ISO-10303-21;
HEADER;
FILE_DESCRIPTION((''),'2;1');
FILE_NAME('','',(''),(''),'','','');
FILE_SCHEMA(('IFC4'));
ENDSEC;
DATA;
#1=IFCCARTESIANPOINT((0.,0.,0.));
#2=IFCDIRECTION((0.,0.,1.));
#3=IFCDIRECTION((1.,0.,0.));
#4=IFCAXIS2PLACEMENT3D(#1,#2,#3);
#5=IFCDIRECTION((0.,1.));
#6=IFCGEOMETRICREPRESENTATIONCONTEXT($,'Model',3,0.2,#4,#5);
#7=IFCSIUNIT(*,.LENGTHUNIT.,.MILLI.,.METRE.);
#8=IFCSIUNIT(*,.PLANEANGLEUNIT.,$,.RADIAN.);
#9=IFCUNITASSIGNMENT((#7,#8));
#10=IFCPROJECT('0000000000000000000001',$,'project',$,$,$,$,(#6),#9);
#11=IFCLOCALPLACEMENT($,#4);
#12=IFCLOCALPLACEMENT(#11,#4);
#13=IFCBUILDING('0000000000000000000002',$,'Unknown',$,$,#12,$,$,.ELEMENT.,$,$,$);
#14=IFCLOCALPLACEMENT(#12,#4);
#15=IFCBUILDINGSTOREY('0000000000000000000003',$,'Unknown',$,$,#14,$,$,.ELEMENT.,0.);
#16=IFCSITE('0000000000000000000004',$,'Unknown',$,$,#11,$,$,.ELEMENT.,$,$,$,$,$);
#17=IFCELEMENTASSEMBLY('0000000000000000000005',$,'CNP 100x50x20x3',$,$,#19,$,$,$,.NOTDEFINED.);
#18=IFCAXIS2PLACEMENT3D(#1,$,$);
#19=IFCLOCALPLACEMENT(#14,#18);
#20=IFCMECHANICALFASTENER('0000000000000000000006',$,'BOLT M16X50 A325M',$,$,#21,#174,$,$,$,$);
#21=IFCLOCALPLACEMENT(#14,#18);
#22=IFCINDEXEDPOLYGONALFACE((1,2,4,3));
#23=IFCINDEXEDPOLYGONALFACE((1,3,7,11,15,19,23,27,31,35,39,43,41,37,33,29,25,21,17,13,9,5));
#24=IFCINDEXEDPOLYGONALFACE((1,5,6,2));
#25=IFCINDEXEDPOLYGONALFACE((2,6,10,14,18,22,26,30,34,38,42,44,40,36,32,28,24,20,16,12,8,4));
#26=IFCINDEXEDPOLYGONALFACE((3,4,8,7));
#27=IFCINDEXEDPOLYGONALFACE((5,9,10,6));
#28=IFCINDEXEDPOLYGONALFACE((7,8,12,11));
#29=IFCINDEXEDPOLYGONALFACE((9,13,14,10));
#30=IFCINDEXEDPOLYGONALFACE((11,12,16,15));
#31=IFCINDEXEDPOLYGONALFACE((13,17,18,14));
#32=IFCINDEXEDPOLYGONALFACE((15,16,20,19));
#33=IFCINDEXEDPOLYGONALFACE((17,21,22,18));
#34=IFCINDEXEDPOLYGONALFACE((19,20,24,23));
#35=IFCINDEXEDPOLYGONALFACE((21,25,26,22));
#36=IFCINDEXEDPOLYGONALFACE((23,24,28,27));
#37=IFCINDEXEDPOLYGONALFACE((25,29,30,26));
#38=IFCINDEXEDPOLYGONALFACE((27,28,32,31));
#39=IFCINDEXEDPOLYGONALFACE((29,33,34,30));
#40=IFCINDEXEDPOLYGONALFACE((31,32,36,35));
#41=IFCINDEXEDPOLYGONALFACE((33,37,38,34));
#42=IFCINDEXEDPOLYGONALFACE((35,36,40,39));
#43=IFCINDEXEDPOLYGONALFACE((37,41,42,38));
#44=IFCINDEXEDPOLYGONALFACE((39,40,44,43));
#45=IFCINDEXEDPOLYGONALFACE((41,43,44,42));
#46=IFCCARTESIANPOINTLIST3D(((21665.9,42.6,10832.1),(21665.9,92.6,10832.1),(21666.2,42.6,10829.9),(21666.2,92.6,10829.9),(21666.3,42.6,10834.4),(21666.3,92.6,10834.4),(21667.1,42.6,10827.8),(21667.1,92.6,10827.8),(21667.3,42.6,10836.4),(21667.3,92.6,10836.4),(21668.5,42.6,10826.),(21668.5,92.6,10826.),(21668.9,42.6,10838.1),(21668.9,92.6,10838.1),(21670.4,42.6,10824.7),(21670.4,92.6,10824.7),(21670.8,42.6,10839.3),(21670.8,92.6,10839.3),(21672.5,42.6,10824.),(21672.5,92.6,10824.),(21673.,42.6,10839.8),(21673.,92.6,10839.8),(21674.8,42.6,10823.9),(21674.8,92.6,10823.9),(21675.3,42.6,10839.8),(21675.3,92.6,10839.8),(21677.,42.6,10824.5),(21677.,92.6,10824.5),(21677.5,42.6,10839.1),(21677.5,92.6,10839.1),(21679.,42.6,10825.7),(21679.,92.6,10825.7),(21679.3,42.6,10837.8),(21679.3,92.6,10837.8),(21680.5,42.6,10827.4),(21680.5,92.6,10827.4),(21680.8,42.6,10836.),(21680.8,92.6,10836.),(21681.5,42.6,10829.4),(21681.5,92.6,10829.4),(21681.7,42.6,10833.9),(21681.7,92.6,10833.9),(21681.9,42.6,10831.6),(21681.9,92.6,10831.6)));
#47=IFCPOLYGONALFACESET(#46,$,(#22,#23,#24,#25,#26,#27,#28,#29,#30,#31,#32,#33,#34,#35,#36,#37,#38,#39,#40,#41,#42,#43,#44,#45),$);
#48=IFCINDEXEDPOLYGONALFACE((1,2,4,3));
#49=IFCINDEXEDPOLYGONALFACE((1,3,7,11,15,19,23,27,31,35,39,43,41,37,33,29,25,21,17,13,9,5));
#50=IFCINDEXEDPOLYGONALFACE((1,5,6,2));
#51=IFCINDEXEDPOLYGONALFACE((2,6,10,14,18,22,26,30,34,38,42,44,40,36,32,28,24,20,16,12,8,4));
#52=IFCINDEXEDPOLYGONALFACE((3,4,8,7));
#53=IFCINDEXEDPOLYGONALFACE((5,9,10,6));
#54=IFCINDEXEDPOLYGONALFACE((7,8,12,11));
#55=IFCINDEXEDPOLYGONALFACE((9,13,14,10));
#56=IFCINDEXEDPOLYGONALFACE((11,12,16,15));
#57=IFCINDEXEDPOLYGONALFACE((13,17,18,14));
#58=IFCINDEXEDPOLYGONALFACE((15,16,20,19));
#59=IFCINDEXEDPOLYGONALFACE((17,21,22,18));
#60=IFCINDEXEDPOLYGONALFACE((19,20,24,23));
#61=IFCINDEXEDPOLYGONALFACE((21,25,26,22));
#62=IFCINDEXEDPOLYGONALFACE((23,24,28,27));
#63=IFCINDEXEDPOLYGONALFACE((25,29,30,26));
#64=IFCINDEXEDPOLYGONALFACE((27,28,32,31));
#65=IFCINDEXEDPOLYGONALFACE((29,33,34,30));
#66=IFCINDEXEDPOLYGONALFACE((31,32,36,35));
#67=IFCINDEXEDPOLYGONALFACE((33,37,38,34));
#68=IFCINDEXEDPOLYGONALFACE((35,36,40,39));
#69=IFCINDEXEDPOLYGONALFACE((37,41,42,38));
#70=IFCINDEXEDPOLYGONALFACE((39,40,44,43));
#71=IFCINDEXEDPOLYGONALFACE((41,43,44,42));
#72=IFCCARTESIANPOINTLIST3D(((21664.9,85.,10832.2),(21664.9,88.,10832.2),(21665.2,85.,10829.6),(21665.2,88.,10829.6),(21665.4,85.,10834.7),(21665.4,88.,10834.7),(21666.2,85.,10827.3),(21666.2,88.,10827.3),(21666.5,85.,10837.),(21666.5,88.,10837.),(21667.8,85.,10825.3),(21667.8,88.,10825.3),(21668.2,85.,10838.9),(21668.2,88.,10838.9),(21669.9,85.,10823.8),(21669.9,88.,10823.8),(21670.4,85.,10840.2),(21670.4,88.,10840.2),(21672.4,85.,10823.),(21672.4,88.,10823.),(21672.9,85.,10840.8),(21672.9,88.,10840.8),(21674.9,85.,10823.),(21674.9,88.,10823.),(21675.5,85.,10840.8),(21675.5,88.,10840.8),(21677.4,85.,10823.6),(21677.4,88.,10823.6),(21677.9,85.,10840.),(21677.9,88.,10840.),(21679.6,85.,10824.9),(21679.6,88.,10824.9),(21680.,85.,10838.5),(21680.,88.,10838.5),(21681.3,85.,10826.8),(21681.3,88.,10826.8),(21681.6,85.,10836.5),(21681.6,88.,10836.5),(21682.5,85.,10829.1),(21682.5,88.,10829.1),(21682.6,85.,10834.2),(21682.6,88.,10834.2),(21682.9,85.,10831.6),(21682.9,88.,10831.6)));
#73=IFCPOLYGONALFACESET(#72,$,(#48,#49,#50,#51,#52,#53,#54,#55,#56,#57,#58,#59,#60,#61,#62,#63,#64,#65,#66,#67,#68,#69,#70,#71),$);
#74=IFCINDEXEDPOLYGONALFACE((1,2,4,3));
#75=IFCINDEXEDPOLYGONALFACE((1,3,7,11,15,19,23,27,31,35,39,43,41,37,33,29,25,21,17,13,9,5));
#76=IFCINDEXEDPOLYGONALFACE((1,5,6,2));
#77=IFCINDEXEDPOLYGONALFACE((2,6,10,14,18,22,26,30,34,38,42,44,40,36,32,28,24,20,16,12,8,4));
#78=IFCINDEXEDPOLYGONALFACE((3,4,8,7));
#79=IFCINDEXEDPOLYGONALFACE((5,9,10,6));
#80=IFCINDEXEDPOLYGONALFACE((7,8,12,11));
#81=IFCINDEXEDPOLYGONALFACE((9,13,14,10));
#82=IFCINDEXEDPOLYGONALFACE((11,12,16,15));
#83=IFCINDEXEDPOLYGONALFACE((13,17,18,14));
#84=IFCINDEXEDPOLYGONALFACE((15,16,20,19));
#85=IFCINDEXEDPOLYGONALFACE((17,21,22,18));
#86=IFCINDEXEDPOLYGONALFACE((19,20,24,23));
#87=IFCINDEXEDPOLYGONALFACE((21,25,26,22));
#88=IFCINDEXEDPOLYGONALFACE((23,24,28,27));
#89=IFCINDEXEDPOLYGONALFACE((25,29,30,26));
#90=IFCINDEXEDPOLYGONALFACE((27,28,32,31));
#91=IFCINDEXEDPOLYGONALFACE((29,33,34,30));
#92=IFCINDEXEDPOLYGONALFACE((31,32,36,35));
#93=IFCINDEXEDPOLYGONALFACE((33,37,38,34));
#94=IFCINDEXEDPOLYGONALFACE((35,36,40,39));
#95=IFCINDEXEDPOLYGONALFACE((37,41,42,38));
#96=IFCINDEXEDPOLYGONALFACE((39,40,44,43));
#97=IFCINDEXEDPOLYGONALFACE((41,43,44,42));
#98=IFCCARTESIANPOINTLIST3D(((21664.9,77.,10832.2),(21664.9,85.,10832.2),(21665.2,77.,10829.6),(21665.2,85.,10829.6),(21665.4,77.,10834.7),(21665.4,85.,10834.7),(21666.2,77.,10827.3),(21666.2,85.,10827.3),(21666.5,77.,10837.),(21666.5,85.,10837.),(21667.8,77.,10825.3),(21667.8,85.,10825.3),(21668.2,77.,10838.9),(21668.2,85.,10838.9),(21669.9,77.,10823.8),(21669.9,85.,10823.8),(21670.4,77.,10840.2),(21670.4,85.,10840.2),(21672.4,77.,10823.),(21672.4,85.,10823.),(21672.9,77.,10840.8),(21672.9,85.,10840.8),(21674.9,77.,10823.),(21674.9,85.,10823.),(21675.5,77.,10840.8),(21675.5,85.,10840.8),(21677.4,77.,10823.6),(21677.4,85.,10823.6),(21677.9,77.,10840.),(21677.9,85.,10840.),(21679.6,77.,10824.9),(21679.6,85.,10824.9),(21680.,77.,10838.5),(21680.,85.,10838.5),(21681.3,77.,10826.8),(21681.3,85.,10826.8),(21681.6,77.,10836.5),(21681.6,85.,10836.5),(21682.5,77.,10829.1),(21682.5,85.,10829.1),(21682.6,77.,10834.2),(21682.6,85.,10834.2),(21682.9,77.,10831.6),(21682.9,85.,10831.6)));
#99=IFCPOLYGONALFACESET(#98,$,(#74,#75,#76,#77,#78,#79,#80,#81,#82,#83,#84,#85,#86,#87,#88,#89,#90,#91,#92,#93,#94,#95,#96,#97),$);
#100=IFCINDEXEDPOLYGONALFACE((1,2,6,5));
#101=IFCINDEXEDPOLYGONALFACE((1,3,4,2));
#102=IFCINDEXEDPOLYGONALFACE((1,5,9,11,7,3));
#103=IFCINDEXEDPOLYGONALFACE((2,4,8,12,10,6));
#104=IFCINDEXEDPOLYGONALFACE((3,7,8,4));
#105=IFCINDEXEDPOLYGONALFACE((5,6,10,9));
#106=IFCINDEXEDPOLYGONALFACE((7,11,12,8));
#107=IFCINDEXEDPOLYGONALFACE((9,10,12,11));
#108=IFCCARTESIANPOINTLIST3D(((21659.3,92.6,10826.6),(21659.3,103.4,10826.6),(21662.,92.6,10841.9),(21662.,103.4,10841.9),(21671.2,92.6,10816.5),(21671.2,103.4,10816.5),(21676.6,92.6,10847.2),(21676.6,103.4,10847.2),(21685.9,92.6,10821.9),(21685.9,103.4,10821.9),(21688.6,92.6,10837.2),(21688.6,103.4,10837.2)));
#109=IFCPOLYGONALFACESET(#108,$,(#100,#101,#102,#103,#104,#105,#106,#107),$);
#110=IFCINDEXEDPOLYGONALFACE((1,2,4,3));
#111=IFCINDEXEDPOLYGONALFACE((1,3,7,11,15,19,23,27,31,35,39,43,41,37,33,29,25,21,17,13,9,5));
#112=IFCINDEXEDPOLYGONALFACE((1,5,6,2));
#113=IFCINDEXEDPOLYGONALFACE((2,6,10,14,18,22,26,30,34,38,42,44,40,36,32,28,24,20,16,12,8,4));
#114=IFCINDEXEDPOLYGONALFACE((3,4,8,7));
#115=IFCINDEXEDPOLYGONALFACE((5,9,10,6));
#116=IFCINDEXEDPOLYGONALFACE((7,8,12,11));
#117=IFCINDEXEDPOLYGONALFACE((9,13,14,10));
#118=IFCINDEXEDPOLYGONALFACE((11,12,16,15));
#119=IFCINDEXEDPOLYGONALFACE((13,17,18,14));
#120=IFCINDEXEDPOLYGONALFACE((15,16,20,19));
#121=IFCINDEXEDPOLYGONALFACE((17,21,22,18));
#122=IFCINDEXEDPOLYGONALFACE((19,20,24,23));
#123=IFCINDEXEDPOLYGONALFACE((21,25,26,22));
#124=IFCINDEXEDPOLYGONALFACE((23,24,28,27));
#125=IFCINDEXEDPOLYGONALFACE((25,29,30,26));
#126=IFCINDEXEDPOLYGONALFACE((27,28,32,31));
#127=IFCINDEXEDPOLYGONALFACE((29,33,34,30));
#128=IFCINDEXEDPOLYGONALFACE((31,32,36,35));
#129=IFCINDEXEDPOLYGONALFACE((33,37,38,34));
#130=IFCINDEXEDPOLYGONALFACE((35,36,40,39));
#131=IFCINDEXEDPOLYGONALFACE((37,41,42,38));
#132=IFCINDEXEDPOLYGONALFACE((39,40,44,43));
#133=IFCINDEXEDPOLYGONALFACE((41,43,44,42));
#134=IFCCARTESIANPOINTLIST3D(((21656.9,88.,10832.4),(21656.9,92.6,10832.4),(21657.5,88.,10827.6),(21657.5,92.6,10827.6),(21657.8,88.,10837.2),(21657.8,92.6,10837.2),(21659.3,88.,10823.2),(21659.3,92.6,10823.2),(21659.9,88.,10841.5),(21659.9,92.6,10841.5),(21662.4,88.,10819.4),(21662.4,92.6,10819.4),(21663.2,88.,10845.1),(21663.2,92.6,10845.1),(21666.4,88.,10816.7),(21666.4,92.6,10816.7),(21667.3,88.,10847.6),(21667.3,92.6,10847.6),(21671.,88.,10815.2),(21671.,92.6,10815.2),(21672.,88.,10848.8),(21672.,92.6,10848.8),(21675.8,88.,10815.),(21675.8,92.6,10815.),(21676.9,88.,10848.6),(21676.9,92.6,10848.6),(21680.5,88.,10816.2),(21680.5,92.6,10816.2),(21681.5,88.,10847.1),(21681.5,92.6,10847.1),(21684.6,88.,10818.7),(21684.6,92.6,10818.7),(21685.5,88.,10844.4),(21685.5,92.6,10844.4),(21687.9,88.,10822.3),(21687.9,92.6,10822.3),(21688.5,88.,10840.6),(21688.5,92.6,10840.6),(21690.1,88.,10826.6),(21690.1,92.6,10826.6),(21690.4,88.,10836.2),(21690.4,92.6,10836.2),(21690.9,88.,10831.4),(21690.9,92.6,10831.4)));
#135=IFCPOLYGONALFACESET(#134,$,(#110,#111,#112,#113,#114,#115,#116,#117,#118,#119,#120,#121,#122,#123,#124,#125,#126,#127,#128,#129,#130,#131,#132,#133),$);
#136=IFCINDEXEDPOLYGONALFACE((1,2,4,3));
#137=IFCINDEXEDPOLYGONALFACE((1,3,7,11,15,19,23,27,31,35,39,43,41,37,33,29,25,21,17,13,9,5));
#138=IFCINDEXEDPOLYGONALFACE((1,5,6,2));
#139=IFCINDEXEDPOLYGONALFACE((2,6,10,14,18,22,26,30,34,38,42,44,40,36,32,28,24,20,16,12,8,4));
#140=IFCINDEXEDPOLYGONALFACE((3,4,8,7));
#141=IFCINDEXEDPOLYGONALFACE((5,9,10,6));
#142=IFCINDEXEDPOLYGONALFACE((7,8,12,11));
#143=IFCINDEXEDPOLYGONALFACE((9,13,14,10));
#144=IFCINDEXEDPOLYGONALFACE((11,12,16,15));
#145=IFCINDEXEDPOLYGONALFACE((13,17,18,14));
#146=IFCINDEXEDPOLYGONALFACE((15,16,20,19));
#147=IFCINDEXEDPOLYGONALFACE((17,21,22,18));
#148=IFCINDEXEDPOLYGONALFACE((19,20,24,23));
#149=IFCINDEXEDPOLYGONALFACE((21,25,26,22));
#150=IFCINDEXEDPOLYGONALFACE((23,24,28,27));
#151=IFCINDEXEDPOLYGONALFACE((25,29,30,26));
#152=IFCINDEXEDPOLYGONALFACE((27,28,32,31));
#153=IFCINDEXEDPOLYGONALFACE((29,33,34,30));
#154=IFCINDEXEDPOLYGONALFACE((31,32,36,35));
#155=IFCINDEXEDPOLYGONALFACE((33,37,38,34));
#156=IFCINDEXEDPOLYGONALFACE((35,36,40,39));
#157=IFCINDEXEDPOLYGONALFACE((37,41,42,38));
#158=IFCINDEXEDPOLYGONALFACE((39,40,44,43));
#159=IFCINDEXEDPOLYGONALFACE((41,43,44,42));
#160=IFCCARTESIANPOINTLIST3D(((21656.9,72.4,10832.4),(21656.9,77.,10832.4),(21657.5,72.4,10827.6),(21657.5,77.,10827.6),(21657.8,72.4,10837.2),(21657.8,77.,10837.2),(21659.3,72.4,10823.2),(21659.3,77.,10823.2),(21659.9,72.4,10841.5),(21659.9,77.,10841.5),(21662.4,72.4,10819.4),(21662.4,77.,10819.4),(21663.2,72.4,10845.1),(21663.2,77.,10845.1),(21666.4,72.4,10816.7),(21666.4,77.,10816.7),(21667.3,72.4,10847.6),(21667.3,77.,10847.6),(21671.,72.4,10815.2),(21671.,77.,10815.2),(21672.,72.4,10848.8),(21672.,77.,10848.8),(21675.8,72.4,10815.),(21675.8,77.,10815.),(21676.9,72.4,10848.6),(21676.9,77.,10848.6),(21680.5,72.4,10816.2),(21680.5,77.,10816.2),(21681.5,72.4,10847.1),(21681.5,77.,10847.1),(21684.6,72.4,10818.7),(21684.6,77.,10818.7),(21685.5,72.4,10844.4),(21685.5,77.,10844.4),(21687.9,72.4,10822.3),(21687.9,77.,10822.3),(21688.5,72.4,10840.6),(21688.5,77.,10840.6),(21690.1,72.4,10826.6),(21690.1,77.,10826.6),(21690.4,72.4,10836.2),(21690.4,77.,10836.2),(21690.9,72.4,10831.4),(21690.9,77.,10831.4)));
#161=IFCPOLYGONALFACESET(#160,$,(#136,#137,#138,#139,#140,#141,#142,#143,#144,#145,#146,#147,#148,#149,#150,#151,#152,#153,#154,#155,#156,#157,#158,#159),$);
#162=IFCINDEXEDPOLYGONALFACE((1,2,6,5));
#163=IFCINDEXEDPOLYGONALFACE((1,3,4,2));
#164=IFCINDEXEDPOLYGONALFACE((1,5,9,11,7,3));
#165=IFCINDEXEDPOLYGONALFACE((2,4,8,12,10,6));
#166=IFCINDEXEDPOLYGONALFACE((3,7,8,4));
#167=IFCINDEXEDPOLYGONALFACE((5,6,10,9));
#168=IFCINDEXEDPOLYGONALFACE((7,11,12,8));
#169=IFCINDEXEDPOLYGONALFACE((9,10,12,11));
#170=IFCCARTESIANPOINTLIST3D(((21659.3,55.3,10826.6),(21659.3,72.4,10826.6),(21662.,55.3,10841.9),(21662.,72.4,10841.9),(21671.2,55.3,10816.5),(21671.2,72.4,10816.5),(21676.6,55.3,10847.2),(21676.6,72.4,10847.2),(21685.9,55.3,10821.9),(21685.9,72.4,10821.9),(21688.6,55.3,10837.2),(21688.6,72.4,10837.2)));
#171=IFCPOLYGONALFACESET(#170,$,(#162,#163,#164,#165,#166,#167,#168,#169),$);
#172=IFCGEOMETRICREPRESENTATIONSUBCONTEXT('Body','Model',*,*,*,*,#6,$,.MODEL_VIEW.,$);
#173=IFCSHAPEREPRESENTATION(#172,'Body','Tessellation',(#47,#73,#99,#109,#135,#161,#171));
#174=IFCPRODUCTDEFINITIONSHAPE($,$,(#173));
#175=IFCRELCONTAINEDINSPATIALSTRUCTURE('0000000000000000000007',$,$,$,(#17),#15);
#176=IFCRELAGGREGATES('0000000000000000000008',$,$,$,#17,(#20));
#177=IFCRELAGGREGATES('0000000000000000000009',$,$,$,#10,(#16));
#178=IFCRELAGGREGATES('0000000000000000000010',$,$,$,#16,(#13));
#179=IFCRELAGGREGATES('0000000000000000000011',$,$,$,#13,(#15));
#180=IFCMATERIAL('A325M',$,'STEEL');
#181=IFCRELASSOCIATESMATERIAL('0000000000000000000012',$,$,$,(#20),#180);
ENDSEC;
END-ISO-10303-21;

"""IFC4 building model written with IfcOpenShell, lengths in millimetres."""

from ifc_helpers import new_model, si_unit, direction, frame, origin_with_axes, place, context, subcontext, project, spatial, line, arc, indexed_curve, outline, extrude, source, transform, mapped, material, element, aggregate, save


model = new_model("IFC4")

# Units and contexts
model_context = context("Model", 3, precision=0.2, world=origin_with_axes(), true_north=direction((0.0, 1.0)))
body_context = subcontext(model_context, "Body", "Model", "MODEL_VIEW")
ifc_project = project(units=[si_unit("LENGTHUNIT", "METRE", prefix="MILLI"), si_unit("PLANEANGLEUNIT", "RADIAN")], contexts=[model_context])

# Site, building, storey
site_placement = place(None, origin_with_axes())
site = spatial("IfcSite", under=ifc_project, at=site_placement, Name="Unknown", CompositionType="ELEMENT")
building_placement = place(site_placement, origin_with_axes())
building = spatial("IfcBuilding", under=site, at=building_placement, Name="Unknown", CompositionType="ELEMENT")
storey_placement = place(building_placement, origin_with_axes())
storey = spatial("IfcBuildingStorey", under=building, at=storey_placement, Name="Unknown", CompositionType="ELEMENT", Elevation=0.0)

# Shared definitions
ifc_material_1 = material(Name="A325M", Category="STEEL")
shared_shape = source(origin_with_axes(), body_context, "Body", "SweptSolid", [
    extrude(outline(indexed_curve([(8.0, 0.0), (0.0, 8.0), (-8.0, 0.0), (0.0, -8.0)], segments=[arc(1, 2, 3), arc(3, 4, 1)])), frame((0.0, 0.0, 15.6), z_axis=(0.0, 0.0, -1.0), x_axis=(0.0, 1.0, 0.0)), (0.0, 0.0, 1.0), 50.0),
    extrude(outline(indexed_curve([(9.0, 0.0), (0.0, 9.0), (-9.0, 0.0), (0.0, -9.0)], segments=[arc(1, 2, 3), arc(3, 4, 1)])), frame((0.0, 0.0, 11.0), z_axis=(0.0, 0.0, -1.0), x_axis=(0.0, 1.0, 0.0)), (0.0, 0.0, 1.0), 3.0),
    extrude(outline(indexed_curve([(9.0, 0.0), (0.0, 9.0), (-9.0, 0.0), (0.0, -9.0)], segments=[arc(1, 2, 3), arc(3, 4, 1)])), frame((0.0, 0.0, 8.0), z_axis=(0.0, 0.0, -1.0), x_axis=(0.0, 1.0, 0.0)), (0.0, 0.0, 1.0), 8.0),
    extrude(outline(indexed_curve([(15.6, 0.0), (7.8, 13.5), (-7.8, 13.5), (-15.6, 0.0), (-7.8, -13.5), (7.8, -13.5)], segments=[line(1, 2, 3, 4, 5, 6, 1)])), frame((0.0, 0.0, 26.4), z_axis=(0.0, 0.0, -1.0), x_axis=(0.0, 1.0, 0.0)), (0.0, 0.0, 1.0), 10.8),
    extrude(outline(indexed_curve([(17.0, 0.0), (0.0, 17.0), (-17.0, 0.0), (0.0, -17.0)], segments=[arc(1, 2, 3), arc(3, 4, 1)])), frame((0.0, 0.0, 15.6), z_axis=(0.0, 0.0, -1.0), x_axis=(0.0, 1.0, 0.0)), (0.0, 0.0, 1.0), 4.6),
    extrude(outline(indexed_curve([(17.0, 0.0), (0.0, 17.0), (-17.0, 0.0), (0.0, -17.0)], segments=[arc(1, 2, 3), arc(3, 4, 1)])), frame((0.0, 0.0, 0.0), z_axis=(0.0, 0.0, -1.0), x_axis=(0.0, 1.0, 0.0)), (0.0, 0.0, 1.0), 4.6),
    extrude(outline(indexed_curve([(15.6, 0.0), (7.8, 13.5), (-7.8, 13.5), (-15.6, 0.0), (-7.8, -13.5), (7.8, -13.5)], segments=[line(1, 2, 3, 4, 5, 6, 1)])), frame((0.0, 0.0, -4.6), z_axis=(0.0, 0.0, -1.0), x_axis=(0.0, 1.0, 0.0)), (0.0, 0.0, 1.0), 17.1),
])

# Element assembly, mechanical fastener
assembly_1_placement = place(storey_placement, frame((25552.5, 110.0, 10153.1), z_axis=(0.173648, 0.0, 0.984808), x_axis=(-0.984808, 0.0, 0.173648)))
assembly_1 = element("IfcElementAssembly", 1, at=assembly_1_placement, inside=storey, Name="CNP 100x50x20x3", PredefinedType="NOTDEFINED")
mechanical_fastener_1_placement = place(assembly_1_placement, frame((3937.5, 33.0, -5.0), z_axis=(0.0, -1.0, 0.0), x_axis=(-1.0, 0.0, 0.0)))
mechanical_fastener_1 = element("IfcMechanicalFastener", 2, at=mechanical_fastener_1_placement, material=ifc_material_1, Name="BOLT M16X50 A325M", context=body_context, shape_type="MappedRepresentation", body=[
    mapped(shared_shape, transform((0.0, 0.0, 0.0))),
])
aggregate(assembly_1, [mechanical_fastener_1])

save(model, "model.ifc")
